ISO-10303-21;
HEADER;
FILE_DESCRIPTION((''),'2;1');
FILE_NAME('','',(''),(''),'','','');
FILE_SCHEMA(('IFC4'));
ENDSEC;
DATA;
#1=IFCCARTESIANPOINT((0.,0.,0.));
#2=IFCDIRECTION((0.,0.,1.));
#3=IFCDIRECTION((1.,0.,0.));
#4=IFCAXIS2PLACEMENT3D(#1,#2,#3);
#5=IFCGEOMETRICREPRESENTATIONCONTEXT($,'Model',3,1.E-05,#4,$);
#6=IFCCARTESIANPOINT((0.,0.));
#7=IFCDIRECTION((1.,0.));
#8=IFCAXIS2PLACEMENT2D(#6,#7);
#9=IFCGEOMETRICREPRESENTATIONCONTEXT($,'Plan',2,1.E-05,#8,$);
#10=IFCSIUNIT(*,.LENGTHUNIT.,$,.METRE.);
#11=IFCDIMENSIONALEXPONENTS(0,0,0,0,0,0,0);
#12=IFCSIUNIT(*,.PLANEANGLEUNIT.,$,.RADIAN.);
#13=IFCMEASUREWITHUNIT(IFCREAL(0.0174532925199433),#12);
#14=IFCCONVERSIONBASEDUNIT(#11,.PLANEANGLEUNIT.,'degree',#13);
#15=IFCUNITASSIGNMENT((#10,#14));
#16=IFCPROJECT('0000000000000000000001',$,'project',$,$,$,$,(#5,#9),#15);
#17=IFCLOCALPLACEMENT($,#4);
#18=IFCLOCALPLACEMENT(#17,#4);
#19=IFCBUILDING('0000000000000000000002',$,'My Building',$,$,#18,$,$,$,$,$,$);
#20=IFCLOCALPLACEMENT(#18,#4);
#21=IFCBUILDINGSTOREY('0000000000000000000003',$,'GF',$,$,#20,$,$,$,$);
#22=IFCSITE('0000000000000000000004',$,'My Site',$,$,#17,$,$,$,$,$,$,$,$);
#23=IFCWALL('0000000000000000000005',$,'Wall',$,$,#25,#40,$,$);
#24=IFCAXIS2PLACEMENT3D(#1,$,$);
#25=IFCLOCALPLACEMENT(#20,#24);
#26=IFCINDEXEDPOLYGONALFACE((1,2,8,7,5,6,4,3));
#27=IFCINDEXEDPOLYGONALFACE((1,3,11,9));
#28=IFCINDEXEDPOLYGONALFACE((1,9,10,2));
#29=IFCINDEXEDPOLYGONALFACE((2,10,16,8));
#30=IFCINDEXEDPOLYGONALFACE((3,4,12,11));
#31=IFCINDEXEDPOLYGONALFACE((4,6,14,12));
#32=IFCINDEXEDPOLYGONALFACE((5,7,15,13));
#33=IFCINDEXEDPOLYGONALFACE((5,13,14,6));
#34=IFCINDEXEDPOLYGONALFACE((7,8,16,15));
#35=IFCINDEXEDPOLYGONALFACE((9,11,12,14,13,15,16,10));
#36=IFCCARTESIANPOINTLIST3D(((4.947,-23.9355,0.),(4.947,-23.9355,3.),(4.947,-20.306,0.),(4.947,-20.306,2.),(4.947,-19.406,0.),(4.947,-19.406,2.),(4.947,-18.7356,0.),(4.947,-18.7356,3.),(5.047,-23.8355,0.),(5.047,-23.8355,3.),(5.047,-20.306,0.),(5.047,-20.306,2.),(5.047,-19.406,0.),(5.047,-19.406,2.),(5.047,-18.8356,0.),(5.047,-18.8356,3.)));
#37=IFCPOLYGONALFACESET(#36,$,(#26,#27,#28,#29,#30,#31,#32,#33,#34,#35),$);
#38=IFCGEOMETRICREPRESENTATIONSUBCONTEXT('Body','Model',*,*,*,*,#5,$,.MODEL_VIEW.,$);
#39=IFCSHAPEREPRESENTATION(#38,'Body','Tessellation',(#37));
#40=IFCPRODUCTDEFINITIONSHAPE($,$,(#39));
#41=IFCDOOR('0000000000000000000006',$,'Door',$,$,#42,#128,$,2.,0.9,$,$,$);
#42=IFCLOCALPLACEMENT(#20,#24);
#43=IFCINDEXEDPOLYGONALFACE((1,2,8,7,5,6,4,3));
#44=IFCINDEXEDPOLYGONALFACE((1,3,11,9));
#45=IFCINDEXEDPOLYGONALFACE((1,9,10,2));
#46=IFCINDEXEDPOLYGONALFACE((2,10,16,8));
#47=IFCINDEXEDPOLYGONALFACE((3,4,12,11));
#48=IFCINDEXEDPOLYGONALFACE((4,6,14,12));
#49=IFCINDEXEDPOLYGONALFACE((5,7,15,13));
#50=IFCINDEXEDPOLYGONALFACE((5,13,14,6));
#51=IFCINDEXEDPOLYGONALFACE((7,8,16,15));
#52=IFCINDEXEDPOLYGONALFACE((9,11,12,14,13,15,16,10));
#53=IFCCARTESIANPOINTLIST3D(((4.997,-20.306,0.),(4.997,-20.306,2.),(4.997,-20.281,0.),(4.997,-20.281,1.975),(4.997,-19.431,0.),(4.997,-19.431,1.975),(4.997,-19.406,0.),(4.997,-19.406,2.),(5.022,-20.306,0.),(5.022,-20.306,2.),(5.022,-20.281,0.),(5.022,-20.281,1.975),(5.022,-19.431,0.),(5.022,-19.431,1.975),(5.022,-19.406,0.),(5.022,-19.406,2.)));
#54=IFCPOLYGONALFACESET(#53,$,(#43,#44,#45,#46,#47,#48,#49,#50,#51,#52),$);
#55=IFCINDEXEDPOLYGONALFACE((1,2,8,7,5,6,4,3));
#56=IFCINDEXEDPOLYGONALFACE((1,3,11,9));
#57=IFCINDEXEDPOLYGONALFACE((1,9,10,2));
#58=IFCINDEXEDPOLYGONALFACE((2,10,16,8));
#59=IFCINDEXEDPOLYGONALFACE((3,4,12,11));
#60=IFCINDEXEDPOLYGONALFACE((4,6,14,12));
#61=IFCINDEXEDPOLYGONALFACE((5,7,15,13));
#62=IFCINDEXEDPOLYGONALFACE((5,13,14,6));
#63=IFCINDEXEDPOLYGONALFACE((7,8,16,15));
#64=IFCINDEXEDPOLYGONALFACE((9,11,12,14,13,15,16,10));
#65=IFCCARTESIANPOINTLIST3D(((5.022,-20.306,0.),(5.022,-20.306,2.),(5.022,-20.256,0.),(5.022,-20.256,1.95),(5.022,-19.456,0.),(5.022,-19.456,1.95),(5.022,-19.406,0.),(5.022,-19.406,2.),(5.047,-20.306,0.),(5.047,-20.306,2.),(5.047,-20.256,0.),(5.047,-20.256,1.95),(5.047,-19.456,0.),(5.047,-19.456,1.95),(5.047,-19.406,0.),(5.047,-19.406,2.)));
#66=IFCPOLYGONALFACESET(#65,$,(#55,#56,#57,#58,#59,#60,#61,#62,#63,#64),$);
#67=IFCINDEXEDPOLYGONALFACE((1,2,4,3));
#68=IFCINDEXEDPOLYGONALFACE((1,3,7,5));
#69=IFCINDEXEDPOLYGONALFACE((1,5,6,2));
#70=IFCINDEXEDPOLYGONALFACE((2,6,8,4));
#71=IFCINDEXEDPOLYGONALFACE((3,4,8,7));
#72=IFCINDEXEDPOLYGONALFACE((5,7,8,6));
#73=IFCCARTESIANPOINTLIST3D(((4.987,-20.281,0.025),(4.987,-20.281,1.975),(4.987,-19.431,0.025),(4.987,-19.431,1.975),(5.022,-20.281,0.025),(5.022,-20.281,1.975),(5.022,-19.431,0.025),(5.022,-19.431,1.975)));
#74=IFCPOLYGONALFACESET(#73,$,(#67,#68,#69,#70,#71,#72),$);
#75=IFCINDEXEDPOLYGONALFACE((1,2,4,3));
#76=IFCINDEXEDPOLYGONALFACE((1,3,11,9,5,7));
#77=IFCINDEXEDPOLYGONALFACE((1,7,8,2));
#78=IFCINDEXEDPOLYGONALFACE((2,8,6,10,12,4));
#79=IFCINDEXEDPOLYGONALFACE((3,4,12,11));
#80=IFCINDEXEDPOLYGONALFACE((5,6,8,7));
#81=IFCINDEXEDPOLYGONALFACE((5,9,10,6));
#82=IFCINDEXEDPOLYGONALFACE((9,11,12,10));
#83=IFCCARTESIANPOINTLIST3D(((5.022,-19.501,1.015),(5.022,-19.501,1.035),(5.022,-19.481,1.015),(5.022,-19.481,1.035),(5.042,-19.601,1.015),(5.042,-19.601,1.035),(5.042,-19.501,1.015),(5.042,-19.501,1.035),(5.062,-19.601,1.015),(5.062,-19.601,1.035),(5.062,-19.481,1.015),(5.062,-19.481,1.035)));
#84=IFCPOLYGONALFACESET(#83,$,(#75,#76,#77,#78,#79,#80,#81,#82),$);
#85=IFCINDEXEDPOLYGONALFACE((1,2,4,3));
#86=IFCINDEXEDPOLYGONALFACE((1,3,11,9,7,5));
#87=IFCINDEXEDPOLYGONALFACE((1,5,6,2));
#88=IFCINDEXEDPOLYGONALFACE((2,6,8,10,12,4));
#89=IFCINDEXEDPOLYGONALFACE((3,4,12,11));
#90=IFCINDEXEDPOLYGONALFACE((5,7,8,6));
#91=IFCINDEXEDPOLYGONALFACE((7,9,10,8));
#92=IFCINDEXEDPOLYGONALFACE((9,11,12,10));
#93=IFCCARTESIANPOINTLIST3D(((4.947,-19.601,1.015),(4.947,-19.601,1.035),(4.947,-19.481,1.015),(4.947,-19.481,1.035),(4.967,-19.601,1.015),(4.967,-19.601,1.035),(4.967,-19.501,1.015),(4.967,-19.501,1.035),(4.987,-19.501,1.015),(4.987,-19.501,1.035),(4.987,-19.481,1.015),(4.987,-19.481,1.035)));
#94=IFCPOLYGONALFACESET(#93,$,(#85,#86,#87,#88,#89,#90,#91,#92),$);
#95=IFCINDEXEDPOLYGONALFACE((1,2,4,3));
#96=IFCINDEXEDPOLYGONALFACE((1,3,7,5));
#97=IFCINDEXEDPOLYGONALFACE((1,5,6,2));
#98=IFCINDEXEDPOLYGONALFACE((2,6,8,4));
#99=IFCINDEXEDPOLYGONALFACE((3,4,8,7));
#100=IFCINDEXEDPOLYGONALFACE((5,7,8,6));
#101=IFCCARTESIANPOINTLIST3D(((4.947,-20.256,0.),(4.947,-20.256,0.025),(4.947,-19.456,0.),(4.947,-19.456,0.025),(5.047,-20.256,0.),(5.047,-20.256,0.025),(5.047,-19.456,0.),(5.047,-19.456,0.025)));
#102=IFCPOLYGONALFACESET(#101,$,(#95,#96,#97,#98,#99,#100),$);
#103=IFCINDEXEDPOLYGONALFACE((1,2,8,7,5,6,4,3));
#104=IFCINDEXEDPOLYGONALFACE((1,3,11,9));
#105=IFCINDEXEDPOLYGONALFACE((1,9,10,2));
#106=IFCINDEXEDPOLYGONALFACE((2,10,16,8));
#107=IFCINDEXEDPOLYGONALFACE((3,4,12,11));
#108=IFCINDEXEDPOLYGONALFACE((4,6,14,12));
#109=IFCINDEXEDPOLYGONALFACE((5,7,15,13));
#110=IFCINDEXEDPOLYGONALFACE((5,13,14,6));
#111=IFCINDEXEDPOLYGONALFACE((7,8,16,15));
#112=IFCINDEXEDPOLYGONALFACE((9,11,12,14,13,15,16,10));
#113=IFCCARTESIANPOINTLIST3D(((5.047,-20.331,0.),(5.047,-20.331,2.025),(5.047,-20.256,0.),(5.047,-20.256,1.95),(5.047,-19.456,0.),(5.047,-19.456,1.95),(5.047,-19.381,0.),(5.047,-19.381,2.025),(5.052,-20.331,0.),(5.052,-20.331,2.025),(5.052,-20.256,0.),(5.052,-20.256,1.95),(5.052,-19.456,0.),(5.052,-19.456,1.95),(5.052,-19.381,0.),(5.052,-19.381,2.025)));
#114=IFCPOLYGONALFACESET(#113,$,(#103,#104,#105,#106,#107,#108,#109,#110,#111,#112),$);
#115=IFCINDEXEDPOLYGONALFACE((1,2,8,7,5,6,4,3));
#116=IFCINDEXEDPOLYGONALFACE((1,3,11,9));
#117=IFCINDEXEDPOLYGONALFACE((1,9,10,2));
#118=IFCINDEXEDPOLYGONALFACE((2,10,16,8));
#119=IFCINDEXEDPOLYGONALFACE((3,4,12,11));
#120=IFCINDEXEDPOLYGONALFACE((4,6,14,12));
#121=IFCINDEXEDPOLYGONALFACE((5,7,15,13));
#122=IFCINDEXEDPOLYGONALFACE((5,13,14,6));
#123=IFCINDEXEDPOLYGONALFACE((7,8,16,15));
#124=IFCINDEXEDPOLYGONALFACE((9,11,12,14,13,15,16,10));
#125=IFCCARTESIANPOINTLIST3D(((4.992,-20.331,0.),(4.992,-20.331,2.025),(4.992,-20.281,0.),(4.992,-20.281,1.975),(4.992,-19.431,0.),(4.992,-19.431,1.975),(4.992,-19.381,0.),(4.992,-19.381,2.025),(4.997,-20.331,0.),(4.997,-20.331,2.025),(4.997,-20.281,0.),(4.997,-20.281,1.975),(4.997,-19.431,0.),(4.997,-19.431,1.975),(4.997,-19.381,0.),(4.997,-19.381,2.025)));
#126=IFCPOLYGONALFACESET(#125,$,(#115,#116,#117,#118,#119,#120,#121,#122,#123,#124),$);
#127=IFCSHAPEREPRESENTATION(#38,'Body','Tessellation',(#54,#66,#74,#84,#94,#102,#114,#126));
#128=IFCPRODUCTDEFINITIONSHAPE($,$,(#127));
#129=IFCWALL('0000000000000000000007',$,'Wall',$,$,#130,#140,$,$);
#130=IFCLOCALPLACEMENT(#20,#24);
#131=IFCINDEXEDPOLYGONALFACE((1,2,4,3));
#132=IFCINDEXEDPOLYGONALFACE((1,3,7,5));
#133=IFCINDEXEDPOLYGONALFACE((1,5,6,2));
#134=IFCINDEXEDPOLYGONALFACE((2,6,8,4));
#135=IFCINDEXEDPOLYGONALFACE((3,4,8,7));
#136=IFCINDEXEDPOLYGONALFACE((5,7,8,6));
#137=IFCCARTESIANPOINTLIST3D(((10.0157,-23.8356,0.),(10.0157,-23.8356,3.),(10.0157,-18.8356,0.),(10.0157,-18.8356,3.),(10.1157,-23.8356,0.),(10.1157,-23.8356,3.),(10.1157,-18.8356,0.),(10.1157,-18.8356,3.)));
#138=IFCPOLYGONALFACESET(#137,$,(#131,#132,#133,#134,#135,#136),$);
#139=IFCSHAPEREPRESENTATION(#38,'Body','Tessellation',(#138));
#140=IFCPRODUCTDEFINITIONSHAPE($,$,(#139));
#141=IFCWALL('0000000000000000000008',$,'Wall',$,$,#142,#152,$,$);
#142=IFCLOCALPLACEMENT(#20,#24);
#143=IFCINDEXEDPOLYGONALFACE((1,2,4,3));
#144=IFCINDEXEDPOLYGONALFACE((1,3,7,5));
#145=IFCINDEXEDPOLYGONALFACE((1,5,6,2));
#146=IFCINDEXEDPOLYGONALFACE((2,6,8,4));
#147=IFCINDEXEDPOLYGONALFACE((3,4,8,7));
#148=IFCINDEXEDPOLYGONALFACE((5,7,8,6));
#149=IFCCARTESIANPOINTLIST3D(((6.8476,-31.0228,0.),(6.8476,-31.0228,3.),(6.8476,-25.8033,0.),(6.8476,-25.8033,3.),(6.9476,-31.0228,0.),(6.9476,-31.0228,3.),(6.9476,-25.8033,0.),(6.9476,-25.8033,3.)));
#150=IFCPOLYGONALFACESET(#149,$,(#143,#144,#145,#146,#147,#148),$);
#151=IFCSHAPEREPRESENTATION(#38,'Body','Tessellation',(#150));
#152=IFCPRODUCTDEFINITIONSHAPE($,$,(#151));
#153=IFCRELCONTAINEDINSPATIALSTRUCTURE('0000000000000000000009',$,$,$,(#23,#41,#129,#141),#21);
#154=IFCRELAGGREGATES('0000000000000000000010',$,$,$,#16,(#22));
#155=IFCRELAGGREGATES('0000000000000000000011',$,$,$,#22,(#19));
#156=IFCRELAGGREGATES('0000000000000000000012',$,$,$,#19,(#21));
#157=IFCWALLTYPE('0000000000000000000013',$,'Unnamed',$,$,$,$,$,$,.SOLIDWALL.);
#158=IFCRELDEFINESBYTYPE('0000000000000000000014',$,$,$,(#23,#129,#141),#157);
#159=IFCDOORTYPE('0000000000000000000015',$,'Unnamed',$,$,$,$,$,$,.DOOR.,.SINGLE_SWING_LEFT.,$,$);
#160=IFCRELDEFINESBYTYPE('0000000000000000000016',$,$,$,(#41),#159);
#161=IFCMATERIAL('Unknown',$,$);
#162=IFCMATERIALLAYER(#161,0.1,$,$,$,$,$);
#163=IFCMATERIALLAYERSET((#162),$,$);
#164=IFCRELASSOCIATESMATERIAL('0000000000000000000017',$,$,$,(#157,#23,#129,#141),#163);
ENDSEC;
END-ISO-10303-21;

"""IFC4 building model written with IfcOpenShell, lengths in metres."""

from ifc_helpers import new_model, entity, si_unit, converted_unit, frame, origin_with_axes, origin_2d_with_axis, place, context, subcontext, project, spatial, line, indexed_curve, outline, extrude, shape, source, transform, mapped, material, layer, layer_set, layer_usage, type_object, type_shapes, element, fill, save


model = new_model("IFC4")

# Units and contexts
model_context = context("Model", 3, precision=1e-05, world=origin_with_axes())
plan_context = context("Plan", 2, precision=1e-05, world=origin_2d_with_axis())
body_context_1 = subcontext(model_context, "Body", "Model", "MODEL_VIEW")
body_context_2 = subcontext(plan_context, "Body", "Plan", "PLAN_VIEW")
ifc_project = project(units=[si_unit("LENGTHUNIT", "METRE"), converted_unit("PLANEANGLEUNIT", "degree", entity("IfcReal", 0.0174532925199433), si_unit("PLANEANGLEUNIT", "RADIAN"), dimensions=[0, 0, 0, 0, 0, 0, 0])], contexts=[model_context, plan_context])

# Site, building, storey
site_placement = place(None, origin_with_axes())
site = spatial("IfcSite", under=ifc_project, at=site_placement, Name="My Site")
building_placement = place(site_placement, origin_with_axes())
building = spatial("IfcBuilding", under=site, at=building_placement, Name="My Building")
storey_placement = place(building_placement, origin_with_axes())
storey = spatial("IfcBuildingStorey", under=building, at=storey_placement, Name="GF")

# Shared definitions
ifc_material = material(Name="Unknown")
ifc_layer = layer(ifc_material, 0.1)
ifc_layer_set = layer_set([ifc_layer])
wall_type = type_object("IfcWallType", Name="Unnamed", PredefinedType="SOLIDWALL", material=ifc_layer_set)

# Shared definitions
shared_shape_1 = source(origin_with_axes(), body_context_1, "Body", "SweptSolid", [
    extrude(outline(indexed_curve([(0.0, 0.0), (0.9, 0.0), (0.9, 2.0), (0.0, 2.0)], segments=[line(1, 2, 3, 4, 1)])), frame((0.0, -0.6, 0.0), z_axis=(0.0, -1.0, 0.0), x_axis=(1.0, 0.0, 0.0)), (0.0, 0.0, -1.0), 1.2),
])
door_type = type_object("IfcDoorType", Name="Unnamed", OperationType="SINGLE_SWING_LEFT", PredefinedType="DOOR")
shared_shape_2 = source(origin_with_axes(), body_context_1, "Body", "SweptSolid", [
    extrude(outline(indexed_curve([(0.0, 0.0), (0.0, 2.0), (0.9, 2.0), (0.9, 0.0), (0.875, 0.0), (0.875, 1.975), (0.025, 1.975), (0.025, 0.0)], segments=[line(1, 2, 3, 4, 5, 6, 7, 8, 1)])), frame((0.0, 0.025, 0.0), z_axis=(0.0, -1.0, 0.0), x_axis=(1.0, 0.0, 0.0)), (0.0, 0.0, -1.0), 0.025),
    extrude(outline(indexed_curve([(0.0, 0.0), (0.0, 2.0), (0.9, 2.0), (0.9, 0.0), (0.85, 0.0), (0.85, 1.95), (0.05, 1.95), (0.05, 0.0)], segments=[line(1, 2, 3, 4, 5, 6, 7, 8, 1)])), frame((0.0, 0.0, 0.0), z_axis=(0.0, -1.0, 0.0), x_axis=(1.0, 0.0, 0.0)), (0.0, 0.0, -1.0), 0.025),
    extrude(outline(indexed_curve([(0.0, 0.0), (0.85, 0.0), (0.85, 0.035), (0.0, 0.035)], segments=[line(1, 2, 3, 4, 1)])), frame((0.025, 0.025, 0.025), z_axis=(0.0, 0.0, 1.0), x_axis=(1.0, 0.0, 0.0)), (0.0, 0.0, 1.0), 1.95),
    extrude(outline(indexed_curve([(0.0, 0.0), (0.0, -0.04), (-0.12, -0.04), (-0.12, -0.02), (-0.02, -0.02), (-0.02, 0.0)], segments=[line(1, 2, 3, 4, 5, 6, 1)])), frame((0.825, 0.025, 1.015), z_axis=(0.0, 0.0, 1.0), x_axis=(1.0, 0.0, 0.0)), (0.0, 0.0, 1.0), 0.02),
    extrude(outline(indexed_curve([(0.0, 0.0), (0.0, 0.04), (-0.12, 0.04), (-0.12, 0.02), (-0.02, 0.02), (-0.02, 0.0)], segments=[line(1, 2, 3, 4, 5, 6, 1)])), frame((0.825, 0.06, 1.015), z_axis=(0.0, 0.0, 1.0), x_axis=(1.0, 0.0, 0.0)), (0.0, 0.0, 1.0), 0.02),
    extrude(outline(indexed_curve([(0.0, 0.0), (0.8, 0.0), (0.8, 0.1), (0.0, 0.1)], segments=[line(1, 2, 3, 4, 1)])), frame((0.05, 0.0, 0.0), z_axis=(0.0, 0.0, 1.0), x_axis=(1.0, 0.0, 0.0)), (0.0, 0.0, 1.0), 0.025),
    extrude(outline(indexed_curve([(0.0, 0.0), (0.0, 2.025), (0.95, 2.025), (0.95, 0.0), (0.875, 0.0), (0.875, 1.95), (0.075, 1.95), (0.075, 0.0)], segments=[line(1, 2, 3, 4, 5, 6, 7, 8, 1)])), frame((-0.025, -0.005, 0.0), z_axis=(0.0, -1.0, 0.0), x_axis=(1.0, 0.0, 0.0)), (0.0, 0.0, -1.0), 0.005),
    extrude(outline(indexed_curve([(0.0, 0.0), (0.0, 2.025), (0.95, 2.025), (0.95, 0.0), (0.9, 0.0), (0.9, 1.975), (0.05, 1.975), (0.05, 0.0)], segments=[line(1, 2, 3, 4, 5, 6, 7, 8, 1)])), frame((-0.025, 0.05, 0.0), z_axis=(0.0, -1.0, 0.0), x_axis=(1.0, 0.0, 0.0)), (0.0, 0.0, -1.0), 0.005),
])
shared_shape_3 = source(origin_with_axes(), body_context_2, "Body", "Curve2D", [
    entity("IfcIndexedPolyCurve", entity("IfcCartesianPointList2D", [[0.0, 0.0], [0.0, 0.05], [0.025, 0.05], [0.025, 0.025], [0.05, 0.025], [0.05, 0.0]]), [entity("IfcLineIndex", [1, 2, 3, 4, 5, 6, 1])]),
    entity("IfcIndexedPolyCurve", entity("IfcCartesianPointList2D", [[0.9, 0.0], [0.9, 0.05], [0.875, 0.05], [0.875, 0.025], [0.85, 0.025], [0.85, 0.0]]), [entity("IfcLineIndex", [1, 2, 3, 4, 5, 6, 1])]),
    entity("IfcTrimmedCurve", entity("IfcEllipse", entity("IfcAxis2Placement2D", entity("IfcCartesianPoint", [0.06, 0.05]), entity("IfcDirection", [1.0, 0.0])), 0.815, 0.85), [entity("IfcCartesianPoint", [0.875, 0.05])], [entity("IfcCartesianPoint", [0.06, 0.9])], True, "CARTESIAN"),
    entity("IfcIndexedPolyCurve", entity("IfcCartesianPointList2D", [[0.025, 0.05], [0.06, 0.05], [0.06, 0.9], [0.025, 0.9]]), [entity("IfcLineIndex", [1, 2, 3, 4, 1])]),
])
type_shapes(door_type, [shared_shape_2, shared_shape_3])

# Wall, opening, door
ifc_layer_usage_1 = layer_usage(ifc_layer_set, "AXIS2", "POSITIVE", 0.0)
wall_1_placement = place(storey_placement, frame((5.047, -23.8355, 0.0), z_axis=(0.0, 0.0, 1.0), x_axis=(0.0, 1.0, 0.0)))
wall_1 = element("IfcWall", 1, at=wall_1_placement, inside=storey, type_object=wall_type, material=ifc_layer_usage_1, Name="Wall", context=body_context_1, shape_type="SweptSolid", body=[
    extrude(outline(indexed_curve([(0.0, 0.0), (-0.1, 0.1), (5.1, 0.1), (5.0, 0.0)], segments=[line(1, 2, 3, 4, 1)])), origin_with_axes(), (0.0, 0.0, 1.0), 3.0),
])
opening_1_placement = place(wall_1_placement, frame((3.5295, 0.0, 0.0), z_axis=(0.0, 0.0, 1.0), x_axis=(1.0, 0.0, 0.0)))
opening_1 = element("IfcOpeningElement", 2, at=opening_1_placement, cuts=wall_1, PredefinedType="OPENING", context=body_context_1, shape_type="MappedRepresentation", body=[
    mapped(shared_shape_1, transform((0.0, 0.0, 0.0), x_axis=(1.0, 0.0, 0.0), y_axis=(0.0, 1.0, 0.0), z_axis=(0.0, 0.0, 1.0), scale=1.0)),
])
door_1_placement = place(opening_1_placement, frame((0.0, 0.0, 0.0), z_axis=(0.0, 0.0, 1.0), x_axis=(1.0, 0.0, 0.0)))
door_1 = element("IfcDoor", 3, at=door_1_placement, inside=storey, type_object=door_type, Name="Door", OverallHeight=2.0, OverallWidth=0.9, shapes=[
    shape(body_context_1, "Body", "MappedRepresentation", [mapped(shared_shape_2, transform((0.0, 0.0, 0.0), x_axis=(1.0, 0.0, 0.0), y_axis=(0.0, 1.0, 0.0), z_axis=(0.0, 0.0, 1.0), scale=1.0))]),
    shape(body_context_2, "Body", "MappedRepresentation", [mapped(shared_shape_3, transform((0.0, 0.0, 0.0), x_axis=(1.0, 0.0, 0.0), y_axis=(0.0, 1.0, 0.0), z_axis=(0.0, 0.0, 1.0), scale=1.0))]),
])
fill(opening_1, door_1)

# Walls
ifc_layer_usage_2 = layer_usage(ifc_layer_set, "AXIS2", "POSITIVE", 0.0)
wall_2_placement = place(storey_placement, frame((10.0157, -18.8356, 0.0), z_axis=(0.0, 0.0, 1.0), x_axis=(0.0, -1.0, 0.0)))
element("IfcWall", 4, at=wall_2_placement, inside=storey, type_object=wall_type, material=ifc_layer_usage_2, Name="Wall", context=body_context_1, shape_type="SweptSolid", body=[
    extrude(outline(indexed_curve([(0.0, 0.0), (0.0, 0.1), (5.0, 0.1), (5.0, 0.0)], segments=[line(1, 2, 3, 4, 1)])), origin_with_axes(), (0.0, 0.0, 1.0), 3.0),
])
ifc_layer_usage_3 = layer_usage(ifc_layer_set, "AXIS2", "POSITIVE", 0.0)
wall_3_placement = place(storey_placement, frame((6.8476, -25.8033, 0.0), z_axis=(0.0, 0.0, 1.0), x_axis=(0.0, -1.0, 0.0)))
element("IfcWall", 5, at=wall_3_placement, inside=storey, type_object=wall_type, material=ifc_layer_usage_3, Name="Wall", context=body_context_1, shape_type="SweptSolid", body=[
    extrude(outline(indexed_curve([(0.0, 0.0), (0.0, 0.1), (5.2195, 0.1), (5.2195, 0.0)], segments=[line(1, 2, 3, 4, 1)])), origin_with_axes(), (0.0, 0.0, 1.0), 3.0),
])

save(model, "model.ifc")
